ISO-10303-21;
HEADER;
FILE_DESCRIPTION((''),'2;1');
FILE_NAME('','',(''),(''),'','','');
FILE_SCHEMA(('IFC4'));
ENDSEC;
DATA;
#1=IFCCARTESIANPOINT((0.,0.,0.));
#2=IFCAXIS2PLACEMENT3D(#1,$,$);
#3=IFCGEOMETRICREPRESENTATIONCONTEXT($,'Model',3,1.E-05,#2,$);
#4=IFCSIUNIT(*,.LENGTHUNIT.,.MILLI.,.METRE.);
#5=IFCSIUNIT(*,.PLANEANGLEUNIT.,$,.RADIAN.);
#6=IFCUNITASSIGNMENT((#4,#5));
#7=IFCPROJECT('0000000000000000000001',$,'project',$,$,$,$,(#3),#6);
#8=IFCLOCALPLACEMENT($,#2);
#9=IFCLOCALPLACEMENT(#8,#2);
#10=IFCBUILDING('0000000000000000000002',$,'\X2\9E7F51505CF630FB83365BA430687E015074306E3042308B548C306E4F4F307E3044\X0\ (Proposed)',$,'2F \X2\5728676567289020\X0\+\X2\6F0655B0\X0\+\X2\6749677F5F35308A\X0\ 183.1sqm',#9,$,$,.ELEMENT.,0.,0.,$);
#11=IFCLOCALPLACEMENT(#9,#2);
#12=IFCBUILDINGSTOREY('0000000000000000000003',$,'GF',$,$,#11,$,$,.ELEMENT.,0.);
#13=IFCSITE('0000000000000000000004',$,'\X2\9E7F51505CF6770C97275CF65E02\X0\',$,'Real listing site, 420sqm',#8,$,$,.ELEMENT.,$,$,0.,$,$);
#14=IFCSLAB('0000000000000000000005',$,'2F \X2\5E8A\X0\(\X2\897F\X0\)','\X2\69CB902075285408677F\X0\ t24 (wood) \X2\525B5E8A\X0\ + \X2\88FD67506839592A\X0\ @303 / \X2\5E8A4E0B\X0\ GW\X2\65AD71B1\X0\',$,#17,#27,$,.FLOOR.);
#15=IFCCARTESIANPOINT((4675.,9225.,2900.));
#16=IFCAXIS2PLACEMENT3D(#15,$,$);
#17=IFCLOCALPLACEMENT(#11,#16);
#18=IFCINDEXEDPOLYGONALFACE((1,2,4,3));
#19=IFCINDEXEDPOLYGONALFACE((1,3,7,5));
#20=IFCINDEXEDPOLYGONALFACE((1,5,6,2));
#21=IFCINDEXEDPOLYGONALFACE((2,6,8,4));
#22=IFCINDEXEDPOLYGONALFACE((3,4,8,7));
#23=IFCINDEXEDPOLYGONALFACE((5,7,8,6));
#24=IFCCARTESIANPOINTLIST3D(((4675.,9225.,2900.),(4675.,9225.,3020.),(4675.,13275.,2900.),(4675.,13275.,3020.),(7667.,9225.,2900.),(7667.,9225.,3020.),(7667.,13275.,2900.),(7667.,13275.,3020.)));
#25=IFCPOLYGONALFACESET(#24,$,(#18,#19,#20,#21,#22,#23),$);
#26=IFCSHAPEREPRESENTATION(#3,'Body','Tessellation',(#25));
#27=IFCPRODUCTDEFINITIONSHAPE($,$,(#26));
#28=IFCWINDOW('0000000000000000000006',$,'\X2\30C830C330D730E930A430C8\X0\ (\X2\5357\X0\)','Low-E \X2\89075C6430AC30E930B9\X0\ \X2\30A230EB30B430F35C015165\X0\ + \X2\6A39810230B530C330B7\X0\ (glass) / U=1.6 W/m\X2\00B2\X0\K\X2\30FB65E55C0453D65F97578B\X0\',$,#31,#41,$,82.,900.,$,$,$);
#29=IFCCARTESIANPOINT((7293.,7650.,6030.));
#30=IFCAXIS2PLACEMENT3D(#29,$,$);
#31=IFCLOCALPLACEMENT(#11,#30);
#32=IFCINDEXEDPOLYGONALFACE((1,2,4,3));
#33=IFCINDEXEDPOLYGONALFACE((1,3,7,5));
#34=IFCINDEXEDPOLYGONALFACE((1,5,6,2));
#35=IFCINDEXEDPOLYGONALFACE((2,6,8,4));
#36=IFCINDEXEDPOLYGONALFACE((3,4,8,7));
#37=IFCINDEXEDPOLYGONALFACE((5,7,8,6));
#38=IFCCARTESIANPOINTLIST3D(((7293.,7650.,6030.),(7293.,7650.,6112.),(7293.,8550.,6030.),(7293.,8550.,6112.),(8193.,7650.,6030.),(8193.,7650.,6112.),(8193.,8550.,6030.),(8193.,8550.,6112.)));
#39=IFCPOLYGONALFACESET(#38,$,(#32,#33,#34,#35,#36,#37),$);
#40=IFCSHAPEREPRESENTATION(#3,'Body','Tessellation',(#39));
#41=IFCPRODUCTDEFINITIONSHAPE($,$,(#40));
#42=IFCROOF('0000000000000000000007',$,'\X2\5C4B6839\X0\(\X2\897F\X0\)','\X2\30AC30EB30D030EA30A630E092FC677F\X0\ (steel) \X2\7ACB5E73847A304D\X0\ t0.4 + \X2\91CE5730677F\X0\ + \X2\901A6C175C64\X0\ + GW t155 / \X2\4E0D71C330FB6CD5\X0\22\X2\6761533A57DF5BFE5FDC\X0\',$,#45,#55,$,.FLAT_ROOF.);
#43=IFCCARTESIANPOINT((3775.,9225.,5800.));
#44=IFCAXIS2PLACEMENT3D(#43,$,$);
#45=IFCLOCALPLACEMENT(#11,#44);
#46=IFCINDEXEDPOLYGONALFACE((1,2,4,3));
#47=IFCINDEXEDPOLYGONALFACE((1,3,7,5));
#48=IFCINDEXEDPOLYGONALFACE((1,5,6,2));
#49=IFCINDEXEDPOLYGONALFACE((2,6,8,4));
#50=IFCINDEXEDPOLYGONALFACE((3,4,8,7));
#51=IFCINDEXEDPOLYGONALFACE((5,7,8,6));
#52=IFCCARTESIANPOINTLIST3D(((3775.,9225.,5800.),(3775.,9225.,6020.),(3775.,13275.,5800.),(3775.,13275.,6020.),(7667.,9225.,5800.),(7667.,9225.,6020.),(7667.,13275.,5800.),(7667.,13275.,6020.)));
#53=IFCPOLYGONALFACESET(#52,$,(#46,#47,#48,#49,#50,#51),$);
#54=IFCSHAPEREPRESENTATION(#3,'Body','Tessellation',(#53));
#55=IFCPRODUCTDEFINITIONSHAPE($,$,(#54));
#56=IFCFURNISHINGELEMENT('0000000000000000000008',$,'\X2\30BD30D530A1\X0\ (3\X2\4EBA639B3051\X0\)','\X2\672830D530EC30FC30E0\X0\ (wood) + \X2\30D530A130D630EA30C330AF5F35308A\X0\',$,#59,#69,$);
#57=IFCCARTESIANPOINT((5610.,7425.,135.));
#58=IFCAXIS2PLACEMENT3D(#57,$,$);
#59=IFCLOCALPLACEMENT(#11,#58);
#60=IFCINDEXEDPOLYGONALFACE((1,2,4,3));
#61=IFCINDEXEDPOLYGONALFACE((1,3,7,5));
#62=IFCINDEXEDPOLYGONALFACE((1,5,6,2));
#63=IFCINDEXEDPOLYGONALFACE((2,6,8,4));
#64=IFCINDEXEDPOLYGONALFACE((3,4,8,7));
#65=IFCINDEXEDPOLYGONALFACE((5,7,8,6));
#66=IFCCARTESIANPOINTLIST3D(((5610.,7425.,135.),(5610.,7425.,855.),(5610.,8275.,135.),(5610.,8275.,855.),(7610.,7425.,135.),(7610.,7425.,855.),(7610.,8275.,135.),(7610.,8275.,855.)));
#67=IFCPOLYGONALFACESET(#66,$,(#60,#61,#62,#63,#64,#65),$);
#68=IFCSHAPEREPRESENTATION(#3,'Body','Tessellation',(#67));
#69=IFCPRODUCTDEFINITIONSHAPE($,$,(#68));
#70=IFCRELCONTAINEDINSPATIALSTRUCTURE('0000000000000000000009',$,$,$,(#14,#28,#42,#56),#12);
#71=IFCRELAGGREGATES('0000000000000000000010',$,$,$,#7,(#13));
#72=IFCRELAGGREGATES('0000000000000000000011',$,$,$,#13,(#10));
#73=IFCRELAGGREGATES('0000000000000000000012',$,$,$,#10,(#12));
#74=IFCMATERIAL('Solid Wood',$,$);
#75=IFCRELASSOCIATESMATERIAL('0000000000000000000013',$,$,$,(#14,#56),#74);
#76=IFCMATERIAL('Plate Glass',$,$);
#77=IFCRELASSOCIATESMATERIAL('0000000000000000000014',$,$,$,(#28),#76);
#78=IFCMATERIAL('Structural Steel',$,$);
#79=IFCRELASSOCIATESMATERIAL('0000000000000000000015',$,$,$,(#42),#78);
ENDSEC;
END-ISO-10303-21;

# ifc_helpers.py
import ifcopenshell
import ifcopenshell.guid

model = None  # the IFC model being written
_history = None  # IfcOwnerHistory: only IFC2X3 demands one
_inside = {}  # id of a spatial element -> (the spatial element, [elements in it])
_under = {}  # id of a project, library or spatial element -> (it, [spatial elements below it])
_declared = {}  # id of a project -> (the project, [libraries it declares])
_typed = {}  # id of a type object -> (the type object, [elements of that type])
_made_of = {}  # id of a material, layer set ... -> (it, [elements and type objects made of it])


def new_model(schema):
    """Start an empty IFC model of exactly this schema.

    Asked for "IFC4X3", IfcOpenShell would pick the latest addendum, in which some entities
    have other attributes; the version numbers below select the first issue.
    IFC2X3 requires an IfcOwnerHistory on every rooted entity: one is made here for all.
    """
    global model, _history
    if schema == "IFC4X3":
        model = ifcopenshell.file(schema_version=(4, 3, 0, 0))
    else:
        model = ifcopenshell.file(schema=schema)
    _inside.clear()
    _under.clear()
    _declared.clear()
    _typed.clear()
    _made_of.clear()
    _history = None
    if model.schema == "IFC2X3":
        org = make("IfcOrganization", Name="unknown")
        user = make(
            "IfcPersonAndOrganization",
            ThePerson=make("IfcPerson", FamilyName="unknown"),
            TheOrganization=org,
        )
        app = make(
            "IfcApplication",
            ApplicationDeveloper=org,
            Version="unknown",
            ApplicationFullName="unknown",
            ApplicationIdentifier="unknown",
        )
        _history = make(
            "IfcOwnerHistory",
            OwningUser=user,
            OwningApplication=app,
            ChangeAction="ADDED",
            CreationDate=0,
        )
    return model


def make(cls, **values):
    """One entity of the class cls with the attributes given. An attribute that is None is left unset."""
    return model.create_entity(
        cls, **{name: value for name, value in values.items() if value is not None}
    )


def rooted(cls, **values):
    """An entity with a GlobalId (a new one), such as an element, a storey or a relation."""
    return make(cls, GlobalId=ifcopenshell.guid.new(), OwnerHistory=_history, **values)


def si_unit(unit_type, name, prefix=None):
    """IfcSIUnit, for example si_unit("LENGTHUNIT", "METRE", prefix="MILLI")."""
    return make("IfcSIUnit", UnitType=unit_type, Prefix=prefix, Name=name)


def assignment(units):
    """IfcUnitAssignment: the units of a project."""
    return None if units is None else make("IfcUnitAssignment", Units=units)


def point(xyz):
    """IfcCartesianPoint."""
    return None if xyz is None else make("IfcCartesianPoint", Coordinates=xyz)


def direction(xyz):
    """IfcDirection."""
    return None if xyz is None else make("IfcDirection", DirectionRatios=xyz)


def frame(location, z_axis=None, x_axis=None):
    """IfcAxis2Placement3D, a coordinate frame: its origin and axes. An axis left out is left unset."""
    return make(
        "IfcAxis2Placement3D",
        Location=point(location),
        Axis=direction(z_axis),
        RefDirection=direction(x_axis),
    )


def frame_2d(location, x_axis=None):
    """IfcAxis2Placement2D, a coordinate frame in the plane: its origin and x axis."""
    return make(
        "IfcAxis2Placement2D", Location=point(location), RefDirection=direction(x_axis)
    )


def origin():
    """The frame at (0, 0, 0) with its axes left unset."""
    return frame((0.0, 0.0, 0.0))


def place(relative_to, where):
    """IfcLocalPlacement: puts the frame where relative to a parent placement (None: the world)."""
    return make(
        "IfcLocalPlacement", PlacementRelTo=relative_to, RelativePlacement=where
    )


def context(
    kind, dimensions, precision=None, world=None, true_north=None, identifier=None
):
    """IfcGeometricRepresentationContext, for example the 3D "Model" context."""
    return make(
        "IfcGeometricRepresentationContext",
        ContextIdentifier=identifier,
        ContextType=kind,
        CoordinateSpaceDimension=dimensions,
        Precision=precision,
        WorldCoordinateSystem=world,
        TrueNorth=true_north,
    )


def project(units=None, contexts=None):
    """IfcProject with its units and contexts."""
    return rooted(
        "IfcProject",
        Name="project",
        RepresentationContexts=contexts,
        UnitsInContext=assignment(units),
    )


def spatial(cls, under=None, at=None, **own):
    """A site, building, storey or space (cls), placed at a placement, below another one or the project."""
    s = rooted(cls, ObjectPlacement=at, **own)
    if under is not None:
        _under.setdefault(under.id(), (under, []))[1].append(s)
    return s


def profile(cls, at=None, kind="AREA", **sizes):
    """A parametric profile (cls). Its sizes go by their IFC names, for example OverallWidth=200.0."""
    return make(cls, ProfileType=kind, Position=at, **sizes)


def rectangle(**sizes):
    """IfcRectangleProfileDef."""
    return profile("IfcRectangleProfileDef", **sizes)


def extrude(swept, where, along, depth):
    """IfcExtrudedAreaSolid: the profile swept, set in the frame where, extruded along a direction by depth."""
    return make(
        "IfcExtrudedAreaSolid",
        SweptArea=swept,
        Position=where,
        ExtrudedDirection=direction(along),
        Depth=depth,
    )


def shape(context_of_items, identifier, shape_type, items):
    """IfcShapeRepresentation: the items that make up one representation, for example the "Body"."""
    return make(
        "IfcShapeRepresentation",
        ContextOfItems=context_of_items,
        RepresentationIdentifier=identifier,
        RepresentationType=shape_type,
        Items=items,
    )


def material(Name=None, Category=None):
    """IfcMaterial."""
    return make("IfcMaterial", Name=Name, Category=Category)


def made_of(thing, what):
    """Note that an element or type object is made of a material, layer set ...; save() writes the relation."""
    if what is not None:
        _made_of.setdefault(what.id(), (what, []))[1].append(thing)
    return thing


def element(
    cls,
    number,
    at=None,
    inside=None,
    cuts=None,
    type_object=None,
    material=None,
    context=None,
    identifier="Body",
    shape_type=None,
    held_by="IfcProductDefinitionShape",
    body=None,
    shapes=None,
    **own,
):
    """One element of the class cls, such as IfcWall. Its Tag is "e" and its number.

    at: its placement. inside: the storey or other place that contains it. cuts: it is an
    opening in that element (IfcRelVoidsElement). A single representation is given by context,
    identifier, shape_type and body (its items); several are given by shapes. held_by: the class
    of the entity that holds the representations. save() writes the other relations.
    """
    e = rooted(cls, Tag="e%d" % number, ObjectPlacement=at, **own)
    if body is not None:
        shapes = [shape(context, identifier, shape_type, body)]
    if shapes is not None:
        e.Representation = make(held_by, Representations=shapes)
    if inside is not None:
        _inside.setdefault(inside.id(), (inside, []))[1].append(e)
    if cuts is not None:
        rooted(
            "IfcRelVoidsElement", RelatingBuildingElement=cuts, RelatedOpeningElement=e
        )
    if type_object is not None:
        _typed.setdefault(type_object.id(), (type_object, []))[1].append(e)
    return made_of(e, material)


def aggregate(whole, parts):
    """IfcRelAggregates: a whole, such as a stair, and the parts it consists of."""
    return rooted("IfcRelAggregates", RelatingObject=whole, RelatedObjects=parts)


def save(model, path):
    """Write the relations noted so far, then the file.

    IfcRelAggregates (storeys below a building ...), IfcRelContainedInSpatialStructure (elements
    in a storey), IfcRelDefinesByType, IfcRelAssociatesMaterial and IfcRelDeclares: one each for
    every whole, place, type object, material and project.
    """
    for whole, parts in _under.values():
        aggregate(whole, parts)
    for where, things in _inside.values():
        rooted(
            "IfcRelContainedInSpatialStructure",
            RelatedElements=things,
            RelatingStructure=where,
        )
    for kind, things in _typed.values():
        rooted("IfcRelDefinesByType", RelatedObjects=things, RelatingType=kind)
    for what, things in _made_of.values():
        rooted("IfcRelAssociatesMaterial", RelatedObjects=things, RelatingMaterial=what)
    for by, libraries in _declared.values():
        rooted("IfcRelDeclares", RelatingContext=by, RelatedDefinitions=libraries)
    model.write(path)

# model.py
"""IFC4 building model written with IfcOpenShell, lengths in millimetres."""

from ifc_helpers import new_model, si_unit, frame, frame_2d, origin, place, context, project, spatial, rectangle, extrude, material, element, save


model = new_model("IFC4")

# Units and contexts
model_context = context("Model", 3, precision=1e-05, world=origin())
ifc_project = project(units=[si_unit("LENGTHUNIT", "METRE", prefix="MILLI"), si_unit("PLANEANGLEUNIT", "RADIAN")], contexts=[model_context])

# Site, building, storey
site_placement = place(None, origin())
site = spatial("IfcSite", under=ifc_project, at=site_placement, Name="鹿児島県霧島市", ObjectType="Real listing site, 420sqm", CompositionType="ELEMENT", RefElevation=0.0)
building_placement = place(site_placement, origin())
building = spatial("IfcBuilding", under=site, at=building_placement, Name="鹿児島・茶室と縁側のある和の住まい (Proposed)", ObjectType="2F 在来木造+漆喰+杉板張り 183.1sqm", CompositionType="ELEMENT", ElevationOfRefHeight=0.0, ElevationOfTerrain=0.0)
storey_placement = place(building_placement, origin())
storey = spatial("IfcBuildingStorey", under=building, at=storey_placement, Name="GF", CompositionType="ELEMENT", Elevation=0.0)

# Shared definitions
ifc_material_1 = material(Name="Solid Wood")

# Slab
slab_1_placement = place(storey_placement, frame((4675.0, 9225.0, 2900.0)))
element("IfcSlab", 1, at=slab_1_placement, inside=storey, material=ifc_material_1, Name="2F 床(西)", Description="構造用合板 t24 (wood) 剛床 + 製材根太 @303 / 床下 GW断熱", PredefinedType="FLOOR", context=model_context, shape_type="SweptSolid", body=[
    extrude(rectangle(XDim=2992.0, YDim=4050.0, at=frame_2d((1496.0, 2025.0))), frame((4675.0, 9225.0, 2900.0)), (0.0, 0.0, 1.0), 120.0),
])

# Window
ifc_material_2 = material(Name="Plate Glass")
window_placement = place(storey_placement, frame((7293.0, 7650.0, 6030.0)))
element("IfcWindow", 2, at=window_placement, inside=storey, material=ifc_material_2, Name="トップライト (南)", Description="Low-E 複層ガラス アルゴン封入 + 樹脂サッシ (glass) / U=1.6 W/m²K・日射取得型", OverallHeight=82.0, OverallWidth=900.0, context=model_context, shape_type="SweptSolid", body=[
    extrude(rectangle(XDim=900.0, YDim=900.0, at=frame_2d((450.0, 450.0))), frame((7293.0, 7650.0, 6030.0)), (0.0, 0.0, 1.0), 82.0),
])

# Roof
ifc_material_3 = material(Name="Structural Steel")
for number, where, name in (
    (3, (3775.0, 9225.0, 5800.0), "屋根(西)"),
):
    element("IfcRoof", number, at=place(storey_placement, frame(where)), inside=storey, material=ifc_material_3, Name=name, Description="ガルバリウム鋼板 (steel) 立平葺き t0.4 + 野地板 + 通気層 + GW t155 / 不燃・法22条区域対応", PredefinedType="FLAT_ROOF", context=model_context, shape_type="SweptSolid", body=[
        extrude(rectangle(XDim=3892.0, YDim=4050.0, at=frame_2d((1946.0, 2025.0))), frame((3775.0, 9225.0, 5800.0)), (0.0, 0.0, 1.0), 220.0),
    ])

# Furnishing element
furnishing_placement = place(storey_placement, frame((5610.0, 7425.0, 135.0)))
element("IfcFurnishingElement", 4, at=furnishing_placement, inside=storey, material=ifc_material_1, Name="ソファ (3人掛け)", Description="木フレーム (wood) + ファブリック張り", context=model_context, shape_type="SweptSolid", body=[
    extrude(rectangle(XDim=2000.0, YDim=850.0, at=frame_2d((1000.0, 425.0))), frame((5610.0, 7425.0, 135.0)), (0.0, 0.0, 1.0), 720.0),
])

save(model, "model.ifc")
